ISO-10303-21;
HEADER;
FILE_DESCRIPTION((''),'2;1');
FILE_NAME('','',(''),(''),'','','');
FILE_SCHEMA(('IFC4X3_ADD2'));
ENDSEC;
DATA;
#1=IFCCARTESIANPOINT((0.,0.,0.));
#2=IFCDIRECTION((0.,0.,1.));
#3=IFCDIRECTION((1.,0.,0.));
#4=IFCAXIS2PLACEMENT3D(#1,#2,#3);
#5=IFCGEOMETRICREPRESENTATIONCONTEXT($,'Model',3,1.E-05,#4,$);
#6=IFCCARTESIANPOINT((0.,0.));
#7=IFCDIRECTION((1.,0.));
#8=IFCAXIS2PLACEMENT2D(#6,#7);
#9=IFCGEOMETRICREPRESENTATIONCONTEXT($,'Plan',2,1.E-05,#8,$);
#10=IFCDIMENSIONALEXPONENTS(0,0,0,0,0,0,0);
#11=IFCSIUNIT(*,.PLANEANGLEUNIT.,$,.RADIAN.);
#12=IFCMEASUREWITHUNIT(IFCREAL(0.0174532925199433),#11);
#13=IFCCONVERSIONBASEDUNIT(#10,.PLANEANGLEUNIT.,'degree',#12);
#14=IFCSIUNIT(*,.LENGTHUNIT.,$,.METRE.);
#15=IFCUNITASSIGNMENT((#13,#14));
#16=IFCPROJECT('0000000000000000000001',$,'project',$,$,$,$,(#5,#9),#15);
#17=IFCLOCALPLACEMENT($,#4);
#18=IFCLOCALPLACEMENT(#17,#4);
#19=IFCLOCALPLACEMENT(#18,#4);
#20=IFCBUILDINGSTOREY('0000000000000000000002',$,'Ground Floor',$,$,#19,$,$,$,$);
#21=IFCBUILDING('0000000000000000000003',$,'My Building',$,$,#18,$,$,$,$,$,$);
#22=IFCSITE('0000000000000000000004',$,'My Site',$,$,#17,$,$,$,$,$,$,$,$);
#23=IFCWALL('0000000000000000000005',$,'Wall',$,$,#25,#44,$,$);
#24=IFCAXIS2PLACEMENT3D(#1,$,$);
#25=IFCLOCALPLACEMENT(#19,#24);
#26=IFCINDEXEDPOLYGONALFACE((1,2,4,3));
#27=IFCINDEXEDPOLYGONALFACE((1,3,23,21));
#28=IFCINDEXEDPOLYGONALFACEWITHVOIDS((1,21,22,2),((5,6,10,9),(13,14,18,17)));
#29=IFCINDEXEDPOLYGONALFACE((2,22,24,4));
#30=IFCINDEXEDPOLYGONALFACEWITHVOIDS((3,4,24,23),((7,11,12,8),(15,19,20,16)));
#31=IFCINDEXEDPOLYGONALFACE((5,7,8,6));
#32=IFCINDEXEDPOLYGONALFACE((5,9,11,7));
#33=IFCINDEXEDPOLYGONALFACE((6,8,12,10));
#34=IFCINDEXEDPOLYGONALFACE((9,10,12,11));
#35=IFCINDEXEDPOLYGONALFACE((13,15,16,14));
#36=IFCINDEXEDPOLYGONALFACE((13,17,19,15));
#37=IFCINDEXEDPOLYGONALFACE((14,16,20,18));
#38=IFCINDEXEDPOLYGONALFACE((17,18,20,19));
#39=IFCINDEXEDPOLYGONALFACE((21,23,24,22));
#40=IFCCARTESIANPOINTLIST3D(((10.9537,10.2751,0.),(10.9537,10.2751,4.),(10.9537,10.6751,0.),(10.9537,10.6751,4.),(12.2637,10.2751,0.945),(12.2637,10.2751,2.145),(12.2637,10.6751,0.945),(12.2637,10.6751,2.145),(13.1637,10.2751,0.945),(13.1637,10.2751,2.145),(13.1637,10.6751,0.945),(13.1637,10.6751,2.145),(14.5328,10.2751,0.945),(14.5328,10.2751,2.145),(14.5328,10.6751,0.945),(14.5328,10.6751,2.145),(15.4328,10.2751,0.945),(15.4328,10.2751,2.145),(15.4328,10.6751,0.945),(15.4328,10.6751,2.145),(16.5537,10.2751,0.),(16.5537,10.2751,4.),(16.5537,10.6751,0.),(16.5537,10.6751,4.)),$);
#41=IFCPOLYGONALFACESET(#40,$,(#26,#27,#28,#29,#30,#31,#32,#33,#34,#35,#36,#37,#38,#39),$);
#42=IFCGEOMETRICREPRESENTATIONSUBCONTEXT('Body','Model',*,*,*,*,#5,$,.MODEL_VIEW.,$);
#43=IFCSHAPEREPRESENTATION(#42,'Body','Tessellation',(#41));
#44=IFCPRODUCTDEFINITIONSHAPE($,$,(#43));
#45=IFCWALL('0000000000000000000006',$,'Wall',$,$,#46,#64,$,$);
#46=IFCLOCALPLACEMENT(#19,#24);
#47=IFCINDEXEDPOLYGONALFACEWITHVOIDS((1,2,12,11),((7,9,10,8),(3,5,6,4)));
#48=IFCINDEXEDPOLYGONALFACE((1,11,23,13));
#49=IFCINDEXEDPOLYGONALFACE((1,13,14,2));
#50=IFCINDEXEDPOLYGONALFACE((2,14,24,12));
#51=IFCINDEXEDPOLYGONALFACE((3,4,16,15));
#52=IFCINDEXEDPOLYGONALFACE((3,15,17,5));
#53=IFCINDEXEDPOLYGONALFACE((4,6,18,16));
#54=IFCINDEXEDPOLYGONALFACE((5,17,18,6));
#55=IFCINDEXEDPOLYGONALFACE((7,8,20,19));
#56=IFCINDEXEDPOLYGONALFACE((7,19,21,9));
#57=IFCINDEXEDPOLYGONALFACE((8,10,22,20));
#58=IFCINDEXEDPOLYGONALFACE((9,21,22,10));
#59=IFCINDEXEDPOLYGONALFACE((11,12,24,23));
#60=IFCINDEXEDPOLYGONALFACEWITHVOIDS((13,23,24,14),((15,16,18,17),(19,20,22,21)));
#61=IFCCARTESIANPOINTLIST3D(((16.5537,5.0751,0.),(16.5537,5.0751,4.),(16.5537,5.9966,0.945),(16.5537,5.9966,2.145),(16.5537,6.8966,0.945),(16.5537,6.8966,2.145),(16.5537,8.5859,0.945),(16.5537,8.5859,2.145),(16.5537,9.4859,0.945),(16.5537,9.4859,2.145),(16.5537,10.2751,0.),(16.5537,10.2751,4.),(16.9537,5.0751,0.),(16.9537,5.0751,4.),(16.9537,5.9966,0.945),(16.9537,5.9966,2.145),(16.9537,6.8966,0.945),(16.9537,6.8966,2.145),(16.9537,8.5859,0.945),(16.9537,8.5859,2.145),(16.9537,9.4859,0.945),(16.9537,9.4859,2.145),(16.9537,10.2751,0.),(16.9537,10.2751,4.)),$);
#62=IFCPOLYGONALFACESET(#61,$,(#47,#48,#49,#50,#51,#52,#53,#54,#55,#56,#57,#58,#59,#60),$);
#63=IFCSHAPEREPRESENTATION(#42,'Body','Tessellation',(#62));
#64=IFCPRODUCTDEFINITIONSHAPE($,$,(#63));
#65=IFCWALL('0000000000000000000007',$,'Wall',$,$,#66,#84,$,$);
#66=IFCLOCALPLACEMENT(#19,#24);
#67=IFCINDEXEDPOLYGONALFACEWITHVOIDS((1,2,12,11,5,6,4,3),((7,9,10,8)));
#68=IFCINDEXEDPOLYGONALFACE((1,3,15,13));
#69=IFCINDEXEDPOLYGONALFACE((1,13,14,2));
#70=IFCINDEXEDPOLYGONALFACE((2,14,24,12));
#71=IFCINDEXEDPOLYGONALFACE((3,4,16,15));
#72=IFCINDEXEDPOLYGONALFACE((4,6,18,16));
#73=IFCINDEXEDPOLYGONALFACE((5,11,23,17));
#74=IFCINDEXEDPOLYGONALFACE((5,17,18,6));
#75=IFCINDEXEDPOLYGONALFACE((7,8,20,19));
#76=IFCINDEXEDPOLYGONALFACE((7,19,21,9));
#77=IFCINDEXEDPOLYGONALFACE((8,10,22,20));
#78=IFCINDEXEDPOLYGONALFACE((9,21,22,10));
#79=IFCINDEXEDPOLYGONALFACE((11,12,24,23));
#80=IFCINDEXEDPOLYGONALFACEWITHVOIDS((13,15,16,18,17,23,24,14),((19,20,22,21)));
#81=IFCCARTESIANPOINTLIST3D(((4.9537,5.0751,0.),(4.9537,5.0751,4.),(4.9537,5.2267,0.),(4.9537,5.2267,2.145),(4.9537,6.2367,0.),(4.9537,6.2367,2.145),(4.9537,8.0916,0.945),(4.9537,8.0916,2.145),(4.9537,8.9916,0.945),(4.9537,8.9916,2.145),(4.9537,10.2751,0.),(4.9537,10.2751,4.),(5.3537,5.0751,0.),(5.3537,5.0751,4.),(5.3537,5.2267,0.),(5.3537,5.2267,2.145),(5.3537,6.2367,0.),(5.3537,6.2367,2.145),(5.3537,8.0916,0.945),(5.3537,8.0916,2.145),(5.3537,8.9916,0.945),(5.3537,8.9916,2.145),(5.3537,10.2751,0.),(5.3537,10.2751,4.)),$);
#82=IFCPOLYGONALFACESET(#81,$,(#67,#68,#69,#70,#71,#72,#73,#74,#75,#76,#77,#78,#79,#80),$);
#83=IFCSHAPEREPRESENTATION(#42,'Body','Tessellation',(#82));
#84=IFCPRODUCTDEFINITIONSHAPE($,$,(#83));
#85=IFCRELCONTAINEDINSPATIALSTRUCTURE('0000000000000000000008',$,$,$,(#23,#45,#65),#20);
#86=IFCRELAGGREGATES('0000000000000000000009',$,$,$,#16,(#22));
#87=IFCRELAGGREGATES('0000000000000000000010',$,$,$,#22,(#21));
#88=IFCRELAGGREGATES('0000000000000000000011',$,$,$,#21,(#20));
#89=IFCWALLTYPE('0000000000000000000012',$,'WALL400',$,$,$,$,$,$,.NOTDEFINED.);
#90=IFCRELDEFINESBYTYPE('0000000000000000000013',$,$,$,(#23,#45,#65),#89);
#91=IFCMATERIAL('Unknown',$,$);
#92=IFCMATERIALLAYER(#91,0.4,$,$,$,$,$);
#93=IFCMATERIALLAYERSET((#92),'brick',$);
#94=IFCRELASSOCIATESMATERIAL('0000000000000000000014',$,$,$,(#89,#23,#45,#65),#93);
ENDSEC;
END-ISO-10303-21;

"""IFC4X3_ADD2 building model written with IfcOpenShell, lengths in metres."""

from ifc_helpers import new_model, entity, si_unit, converted_unit, frame, origin_with_axes, origin_2d_with_axis, place, context, subcontext, project, spatial, line, indexed_curve, outline, extrude, source, transform, mapped, material, layer, layer_set, layer_usage, type_object, element, save


model = new_model("IFC4X3_ADD2")

# Units and contexts
model_context = context("Model", 3, precision=1e-05, world=origin_with_axes())
plan_context = context("Plan", 2, precision=1e-05, world=origin_2d_with_axis())
body_context = subcontext(model_context, "Body", "Model", "MODEL_VIEW")
ifc_project = project(units=[converted_unit("PLANEANGLEUNIT", "degree", entity("IfcReal", 0.0174532925199433), si_unit("PLANEANGLEUNIT", "RADIAN"), dimensions=[0, 0, 0, 0, 0, 0, 0]), si_unit("LENGTHUNIT", "METRE")], contexts=[model_context, plan_context])

# Site, building, storey
site_placement = place(None, origin_with_axes())
site = spatial("IfcSite", under=ifc_project, at=site_placement, Name="My Site")
building_placement = place(site_placement, origin_with_axes())
building = spatial("IfcBuilding", under=site, at=building_placement, Name="My Building")
storey_placement = place(building_placement, origin_with_axes())
storey = spatial("IfcBuildingStorey", under=building, at=storey_placement, Name="Ground Floor")

# Shared definitions
ifc_material = material(Name="Unknown")

# Walls, openings
ifc_layer_1 = layer(ifc_material, 0.4)
ifc_layer_set_1 = layer_set([ifc_layer_1], Name="brick")
wall_type = type_object("IfcWallType", Name="WALL400", PredefinedType="NOTDEFINED", material=ifc_layer_set_1)
shared_shape_1 = source(origin_with_axes(), body_context, "Body", "SweptSolid", [
    extrude(outline(indexed_curve([(0.0, 0.0), (0.9, 0.0), (0.9, 1.2), (0.0, 1.2)], segments=[line(1, 2, 3, 4, 1)])), frame((0.0, -0.6, 0.0), z_axis=(0.0, -1.0, 0.0), x_axis=(1.0, 0.0, 0.0)), (0.0, 0.0, -1.0), 1.2),
])
ifc_layer_usage_1 = layer_usage(ifc_layer_set_1, "AXIS2", "POSITIVE", 0.0)
wall_1_placement = place(storey_placement, frame((10.9537, 10.2751, 0.0), z_axis=(0.0, 0.0, 1.0), x_axis=(1.0, 0.0, 0.0)))
wall_1 = element("IfcWall", 1, at=wall_1_placement, inside=storey, type_object=wall_type, material=ifc_layer_usage_1, Name="Wall", context=body_context, shape_type="SweptSolid", body=[
    extrude(outline(indexed_curve([(0.0, 0.0), (0.0, 0.4), (5.6, 0.4), (5.6, 0.0)], segments=[line(1, 2, 3, 4, 1)])), origin_with_axes(), (0.0, 0.0, 1.0), 4.0),
])
opening_1_placement = place(wall_1_placement, frame((4.4791, 0.4, 0.945), z_axis=(0.0, 0.0, 1.0), x_axis=(-1.0, 0.0, 0.0)))
element("IfcOpeningElement", 2, at=opening_1_placement, cuts=wall_1, PredefinedType="OPENING", context=body_context, shape_type="MappedRepresentation", body=[
    mapped(shared_shape_1, transform((0.0, 0.0, 0.0), x_axis=(1.0, 0.0, 0.0), y_axis=(0.0, 1.0, 0.0), z_axis=(0.0, 0.0, 1.0), scale=1.0)),
])
opening_2_placement = place(wall_1_placement, frame((2.21, 0.4, 0.945), z_axis=(0.0, 0.0, 1.0), x_axis=(-1.0, 0.0, 0.0)))
element("IfcOpeningElement", 3, at=opening_2_placement, cuts=wall_1, PredefinedType="OPENING", context=body_context, shape_type="MappedRepresentation", body=[
    mapped(shared_shape_1, transform((0.0, 0.0, 0.0), x_axis=(1.0, 0.0, 0.0), y_axis=(0.0, 1.0, 0.0), z_axis=(0.0, 0.0, 1.0), scale=1.0)),
])
ifc_layer_usage_2 = layer_usage(ifc_layer_set_1, "AXIS2", "POSITIVE", 0.0)
wall_2_placement = place(storey_placement, frame((16.9537, 5.0751, 0.0), z_axis=(0.0, 0.0, 1.0), x_axis=(0.0, 1.0, 0.0)))
wall_2 = element("IfcWall", 4, at=wall_2_placement, inside=storey, type_object=wall_type, material=ifc_layer_usage_2, Name="Wall", context=body_context, shape_type="SweptSolid", body=[
    extrude(outline(indexed_curve([(0.0, 0.0), (0.0, 0.4), (5.2, 0.4), (5.2, 0.0)], segments=[line(1, 2, 3, 4, 1)])), origin_with_axes(), (0.0, 0.0, 1.0), 4.0),
])
opening_3_placement = place(wall_2_placement, frame((0.9215, 0.0, 0.945), z_axis=(0.0, 0.0, 1.0), x_axis=(1.0, 0.0, 0.0)))
element("IfcOpeningElement", 5, at=opening_3_placement, cuts=wall_2, PredefinedType="OPENING", context=body_context, shape_type="MappedRepresentation", body=[
    mapped(shared_shape_1, transform((0.0, 0.0, 0.0), x_axis=(1.0, 0.0, 0.0), y_axis=(0.0, 1.0, 0.0), z_axis=(0.0, 0.0, 1.0), scale=1.0)),
])
opening_4_placement = place(wall_2_placement, frame((3.5108, 0.0, 0.945), z_axis=(0.0, 0.0, 1.0), x_axis=(1.0, 0.0, 0.0)))
element("IfcOpeningElement", 6, at=opening_4_placement, cuts=wall_2, PredefinedType="OPENING", context=body_context, shape_type="MappedRepresentation", body=[
    mapped(shared_shape_1, transform((0.0, 0.0, 0.0), x_axis=(1.0, 0.0, 0.0), y_axis=(0.0, 1.0, 0.0), z_axis=(0.0, 0.0, 1.0), scale=1.0)),
])
ifc_layer_usage_3 = layer_usage(ifc_layer_set_1, "AXIS2", "POSITIVE", 0.0)
wall_3_placement = place(storey_placement, frame((5.3537, 5.0751, 0.0), z_axis=(0.0, 0.0, 1.0), x_axis=(0.0, 1.0, 0.0)))
wall_3 = element("IfcWall", 7, at=wall_3_placement, inside=storey, type_object=wall_type, material=ifc_layer_usage_3, Name="Wall", context=body_context, shape_type="SweptSolid", body=[
    extrude(outline(indexed_curve([(0.0, 0.0), (0.0, 0.4), (5.2, 0.4), (5.2, 0.0)], segments=[line(1, 2, 3, 4, 1)])), origin_with_axes(), (0.0, 0.0, 1.0), 4.0),
])
shared_shape_2 = source(origin_with_axes(), body_context, "Body", "SweptSolid", [
    extrude(outline(indexed_curve([(0.0, 0.0), (1.01, 0.0), (1.01, 2.145), (0.0, 2.145)], segments=[line(1, 2, 3, 4, 1)])), frame((0.0, -0.6, 0.0), z_axis=(0.0, -1.0, 0.0), x_axis=(1.0, 0.0, 0.0)), (0.0, 0.0, -1.0), 1.2),
])
opening_5_placement = place(wall_3_placement, frame((1.1617, 0.4, 0.0), z_axis=(0.0, 0.0, 1.0), x_axis=(-1.0, 0.0, 0.0)))
element("IfcOpeningElement", 8, at=opening_5_placement, cuts=wall_3, PredefinedType="OPENING", context=body_context, shape_type="MappedRepresentation", body=[
    mapped(shared_shape_2, transform((0.0, 0.0, 0.0), x_axis=(1.0, 0.0, 0.0), y_axis=(0.0, 1.0, 0.0), z_axis=(0.0, 0.0, 1.0), scale=1.0)),
])
opening_6_placement = place(wall_3_placement, frame((3.9166, 0.4, 0.945), z_axis=(0.0, 0.0, 1.0), x_axis=(-1.0, 0.0, 0.0)))
element("IfcOpeningElement", 9, at=opening_6_placement, cuts=wall_3, PredefinedType="OPENING", context=body_context, shape_type="MappedRepresentation", body=[
    mapped(shared_shape_1, transform((0.0, 0.0, 0.0), x_axis=(1.0, 0.0, 0.0), y_axis=(0.0, 1.0, 0.0), z_axis=(0.0, 0.0, 1.0), scale=1.0)),
])

save(model, "model.ifc")
